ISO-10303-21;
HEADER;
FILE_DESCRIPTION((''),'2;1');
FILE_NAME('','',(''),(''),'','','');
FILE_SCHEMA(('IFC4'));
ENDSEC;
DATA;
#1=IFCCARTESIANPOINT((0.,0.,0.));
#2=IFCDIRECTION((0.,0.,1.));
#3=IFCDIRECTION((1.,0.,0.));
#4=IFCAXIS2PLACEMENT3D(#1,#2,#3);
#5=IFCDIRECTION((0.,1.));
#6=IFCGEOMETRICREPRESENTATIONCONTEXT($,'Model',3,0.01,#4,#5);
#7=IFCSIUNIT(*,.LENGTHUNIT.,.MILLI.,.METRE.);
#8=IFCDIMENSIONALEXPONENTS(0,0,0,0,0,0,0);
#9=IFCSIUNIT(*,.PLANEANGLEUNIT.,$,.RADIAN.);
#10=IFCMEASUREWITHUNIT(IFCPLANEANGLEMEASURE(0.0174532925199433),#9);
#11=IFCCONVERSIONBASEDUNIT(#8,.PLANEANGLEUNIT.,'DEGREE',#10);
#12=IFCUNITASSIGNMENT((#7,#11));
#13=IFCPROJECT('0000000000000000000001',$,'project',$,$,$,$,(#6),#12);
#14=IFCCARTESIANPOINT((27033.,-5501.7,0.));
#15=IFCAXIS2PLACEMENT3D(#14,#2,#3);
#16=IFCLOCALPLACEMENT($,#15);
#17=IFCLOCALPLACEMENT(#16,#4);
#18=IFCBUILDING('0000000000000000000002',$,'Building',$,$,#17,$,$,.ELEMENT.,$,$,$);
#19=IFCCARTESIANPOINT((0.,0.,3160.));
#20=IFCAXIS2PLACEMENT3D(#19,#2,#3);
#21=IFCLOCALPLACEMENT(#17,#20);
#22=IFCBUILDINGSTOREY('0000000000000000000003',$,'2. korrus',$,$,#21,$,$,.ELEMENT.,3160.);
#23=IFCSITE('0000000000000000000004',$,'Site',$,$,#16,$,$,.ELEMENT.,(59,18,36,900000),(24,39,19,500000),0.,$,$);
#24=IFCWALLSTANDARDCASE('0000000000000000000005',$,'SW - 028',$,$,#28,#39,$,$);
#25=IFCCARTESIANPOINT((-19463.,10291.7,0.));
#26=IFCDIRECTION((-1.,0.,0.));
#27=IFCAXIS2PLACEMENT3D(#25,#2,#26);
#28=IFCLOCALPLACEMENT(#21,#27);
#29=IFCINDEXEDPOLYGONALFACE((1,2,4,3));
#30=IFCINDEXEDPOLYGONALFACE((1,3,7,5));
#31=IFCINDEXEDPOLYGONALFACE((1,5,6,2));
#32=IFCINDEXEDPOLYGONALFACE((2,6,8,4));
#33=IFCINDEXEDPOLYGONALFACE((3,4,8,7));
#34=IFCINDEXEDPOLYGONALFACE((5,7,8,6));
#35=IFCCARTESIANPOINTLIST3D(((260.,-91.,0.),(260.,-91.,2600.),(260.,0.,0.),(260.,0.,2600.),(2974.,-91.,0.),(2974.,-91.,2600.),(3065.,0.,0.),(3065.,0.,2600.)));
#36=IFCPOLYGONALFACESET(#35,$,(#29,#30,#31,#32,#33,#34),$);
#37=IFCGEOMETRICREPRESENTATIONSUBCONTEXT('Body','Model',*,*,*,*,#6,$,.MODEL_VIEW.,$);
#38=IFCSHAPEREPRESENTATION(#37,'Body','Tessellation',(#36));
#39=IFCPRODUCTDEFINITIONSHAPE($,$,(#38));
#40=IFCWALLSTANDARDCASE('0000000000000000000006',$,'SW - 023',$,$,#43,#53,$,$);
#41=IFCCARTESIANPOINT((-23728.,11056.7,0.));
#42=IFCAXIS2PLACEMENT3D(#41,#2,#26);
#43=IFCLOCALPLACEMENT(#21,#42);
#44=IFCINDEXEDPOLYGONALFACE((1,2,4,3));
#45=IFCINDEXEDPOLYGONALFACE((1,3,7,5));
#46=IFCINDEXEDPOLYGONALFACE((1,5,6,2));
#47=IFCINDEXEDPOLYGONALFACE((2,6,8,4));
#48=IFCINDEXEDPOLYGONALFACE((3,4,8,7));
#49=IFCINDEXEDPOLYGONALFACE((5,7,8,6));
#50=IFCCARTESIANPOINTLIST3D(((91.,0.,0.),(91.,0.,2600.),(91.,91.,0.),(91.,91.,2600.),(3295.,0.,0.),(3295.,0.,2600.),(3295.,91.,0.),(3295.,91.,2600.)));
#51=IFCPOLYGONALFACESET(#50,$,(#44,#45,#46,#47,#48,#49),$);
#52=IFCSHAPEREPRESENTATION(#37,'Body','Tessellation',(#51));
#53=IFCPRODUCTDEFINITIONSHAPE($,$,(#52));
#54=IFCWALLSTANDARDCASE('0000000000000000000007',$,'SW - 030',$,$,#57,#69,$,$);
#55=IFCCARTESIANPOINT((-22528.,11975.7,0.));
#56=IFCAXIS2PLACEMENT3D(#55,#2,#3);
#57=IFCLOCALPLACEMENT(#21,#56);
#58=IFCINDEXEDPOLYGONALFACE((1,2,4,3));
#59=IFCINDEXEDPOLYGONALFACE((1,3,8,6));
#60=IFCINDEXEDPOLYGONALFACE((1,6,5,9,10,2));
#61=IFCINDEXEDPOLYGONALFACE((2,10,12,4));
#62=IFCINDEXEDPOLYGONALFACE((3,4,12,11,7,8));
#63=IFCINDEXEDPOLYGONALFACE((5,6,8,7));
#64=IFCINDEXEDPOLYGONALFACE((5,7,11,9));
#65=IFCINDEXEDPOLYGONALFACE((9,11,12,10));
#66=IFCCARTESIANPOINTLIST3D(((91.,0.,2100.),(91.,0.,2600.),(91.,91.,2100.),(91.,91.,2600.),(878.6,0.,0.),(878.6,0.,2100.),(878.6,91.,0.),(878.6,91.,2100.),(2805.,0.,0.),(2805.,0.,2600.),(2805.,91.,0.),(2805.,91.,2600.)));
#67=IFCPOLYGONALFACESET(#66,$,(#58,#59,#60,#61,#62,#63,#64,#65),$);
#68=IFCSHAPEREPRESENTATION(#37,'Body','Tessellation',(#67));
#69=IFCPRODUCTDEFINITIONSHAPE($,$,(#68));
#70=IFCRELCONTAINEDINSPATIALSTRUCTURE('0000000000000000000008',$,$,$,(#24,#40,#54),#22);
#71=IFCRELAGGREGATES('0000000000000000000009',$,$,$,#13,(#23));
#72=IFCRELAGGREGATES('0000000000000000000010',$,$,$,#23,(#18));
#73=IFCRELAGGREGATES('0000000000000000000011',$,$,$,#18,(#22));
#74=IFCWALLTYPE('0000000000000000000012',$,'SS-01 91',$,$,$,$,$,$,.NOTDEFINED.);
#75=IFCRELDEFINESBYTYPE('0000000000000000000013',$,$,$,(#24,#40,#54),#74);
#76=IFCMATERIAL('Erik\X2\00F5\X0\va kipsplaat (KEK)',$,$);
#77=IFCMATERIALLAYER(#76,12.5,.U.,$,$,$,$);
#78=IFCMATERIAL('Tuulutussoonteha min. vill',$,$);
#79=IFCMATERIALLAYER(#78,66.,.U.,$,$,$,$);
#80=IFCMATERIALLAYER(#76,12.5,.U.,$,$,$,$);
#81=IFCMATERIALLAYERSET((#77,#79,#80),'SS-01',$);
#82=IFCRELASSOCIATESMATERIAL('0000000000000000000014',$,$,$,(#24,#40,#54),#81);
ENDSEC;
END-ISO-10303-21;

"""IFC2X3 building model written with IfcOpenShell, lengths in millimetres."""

from ifc_helpers import new_model, entity, si_unit, converted_unit, direction, frame, origin_with_axes, origin_2d_with_axis, place, context, subcontext, project, spatial, polyline, rectangle, outline, extrude, material, layer, layer_set, layer_usage, type_object, element, save


model = new_model("IFC2X3")

# Units and contexts
model_context = context("Model", 3, precision=0.01, world=origin_with_axes(), true_north=direction((0.0, 1.0)))
body_context = subcontext(model_context, "Body", "Model", "MODEL_VIEW")
ifc_project = project(units=[si_unit("LENGTHUNIT", "METRE", prefix="MILLI"), converted_unit("PLANEANGLEUNIT", "DEGREE", entity("IfcPlaneAngleMeasure", 0.0174532925199433), si_unit("PLANEANGLEUNIT", "RADIAN"), dimensions=[0, 0, 0, 0, 0, 0, 0])], contexts=[model_context])

# Site, building, storey
site_placement = place(None, frame((27033.0, -5501.7, 0.0), z_axis=(0.0, 0.0, 1.0), x_axis=(1.0, 0.0, 0.0)))
site = spatial("IfcSite", under=ifc_project, at=site_placement, Name="Site", CompositionType="ELEMENT", RefLatitude=(59, 18, 36, 900000), RefLongitude=(24, 39, 19, 500000), RefElevation=0.0)
building_placement = place(site_placement, origin_with_axes())
building = spatial("IfcBuilding", under=site, at=building_placement, Name="Building", CompositionType="ELEMENT")
storey_placement = place(building_placement, frame((0.0, 0.0, 3160.0), z_axis=(0.0, 0.0, 1.0), x_axis=(1.0, 0.0, 0.0)))
storey = spatial("IfcBuildingStorey", under=building, at=storey_placement, Name="2. korrus", CompositionType="ELEMENT", Elevation=3160.0)

# Shared definitions
ifc_material_1 = material(Name="Erikõva kipsplaat (KEK)")
ifc_layer_1 = layer(ifc_material_1, 12.5, ventilated="UNKNOWN")
ifc_material_2 = material(Name="Tuulutussoonteha min. vill")
ifc_layer_2 = layer(ifc_material_2, 66.0, ventilated="UNKNOWN")
ifc_layer_3 = layer(ifc_material_1, 12.5, ventilated="UNKNOWN")
ifc_layer_set_1 = layer_set([ifc_layer_1, ifc_layer_2, ifc_layer_3], Name="SS-01")
wall_type_1 = type_object("IfcWallType", Name="SS-01 91", PredefinedType="NOTDEFINED")

# Wall
ifc_layer_usage_1 = layer_usage(ifc_layer_set_1, "AXIS2", "POSITIVE", -91.0)
wall_1_placement = place(storey_placement, frame((-19463.0, 10291.7, 0.0), z_axis=(0.0, 0.0, 1.0), x_axis=(-1.0, 0.0, 0.0)))
element("IfcWallStandardCase", 1, at=wall_1_placement, inside=storey, type_object=wall_type_1, material=ifc_layer_usage_1, Name="SW - 028", context=body_context, shape_type="SweptSolid", body=[
    extrude(outline(polyline([(260.0, -91.0), (2974.0, -91.0), (3065.0, 0.0), (260.0, 0.0), (260.0, -91.0)])), origin_with_axes(), (0.0, 0.0, 1.0), 2600.0),
])

# Wall
ifc_layer_usage_2 = layer_usage(ifc_layer_set_1, "AXIS2", "NEGATIVE", 91.0)
wall_2_placement = place(storey_placement, frame((-23728.0, 11056.7, 0.0), z_axis=(0.0, 0.0, 1.0), x_axis=(-1.0, 0.0, 0.0)))
element("IfcWallStandardCase", 2, at=wall_2_placement, inside=storey, type_object=wall_type_1, material=ifc_layer_usage_2, Name="SW - 023", context=body_context, shape_type="SweptSolid", body=[
    extrude(outline(polyline([(91.0, 0.0), (3295.0, 0.0), (3295.0, 91.0), (91.0, 91.0), (91.0, 0.0)])), origin_with_axes(), (0.0, 0.0, 1.0), 2600.0),
])

# Wall, opening
ifc_layer_usage_3 = layer_usage(ifc_layer_set_1, "AXIS2", "NEGATIVE", 91.0)
wall_3_placement = place(storey_placement, frame((-22528.0, 11975.7, 0.0), z_axis=(0.0, 0.0, 1.0), x_axis=(1.0, 0.0, 0.0)))
wall_3 = element("IfcWallStandardCase", 3, at=wall_3_placement, inside=storey, type_object=wall_type_1, material=ifc_layer_usage_3, Name="SW - 030", context=body_context, shape_type="SweptSolid", body=[
    extrude(outline(polyline([(91.0, 0.0), (2805.0, 0.0), (2805.0, 91.0), (91.0, 91.0), (91.0, 0.0)])), origin_with_axes(), (0.0, 0.0, 1.0), 2600.0),
])
opening_1_placement = place(wall_3_placement, frame((478.6, 0.0, 0.0), z_axis=(0.0, 0.0, 1.0), x_axis=(1.0, 0.0, 0.0)))
element("IfcOpeningElement", 4, at=opening_1_placement, cuts=wall_3, context=body_context, shape_type="SweptSolid", body=[
    extrude(rectangle(XDim=800.0, YDim=2100.0, at=origin_2d_with_axis()), frame((0.0, -91.0, 1050.0), z_axis=(0.0, 1.0, 0.0), x_axis=(1.0, 0.0, 0.0)), (0.0, 0.0, 1.0), 273.0),
])

save(model, "model.ifc")
